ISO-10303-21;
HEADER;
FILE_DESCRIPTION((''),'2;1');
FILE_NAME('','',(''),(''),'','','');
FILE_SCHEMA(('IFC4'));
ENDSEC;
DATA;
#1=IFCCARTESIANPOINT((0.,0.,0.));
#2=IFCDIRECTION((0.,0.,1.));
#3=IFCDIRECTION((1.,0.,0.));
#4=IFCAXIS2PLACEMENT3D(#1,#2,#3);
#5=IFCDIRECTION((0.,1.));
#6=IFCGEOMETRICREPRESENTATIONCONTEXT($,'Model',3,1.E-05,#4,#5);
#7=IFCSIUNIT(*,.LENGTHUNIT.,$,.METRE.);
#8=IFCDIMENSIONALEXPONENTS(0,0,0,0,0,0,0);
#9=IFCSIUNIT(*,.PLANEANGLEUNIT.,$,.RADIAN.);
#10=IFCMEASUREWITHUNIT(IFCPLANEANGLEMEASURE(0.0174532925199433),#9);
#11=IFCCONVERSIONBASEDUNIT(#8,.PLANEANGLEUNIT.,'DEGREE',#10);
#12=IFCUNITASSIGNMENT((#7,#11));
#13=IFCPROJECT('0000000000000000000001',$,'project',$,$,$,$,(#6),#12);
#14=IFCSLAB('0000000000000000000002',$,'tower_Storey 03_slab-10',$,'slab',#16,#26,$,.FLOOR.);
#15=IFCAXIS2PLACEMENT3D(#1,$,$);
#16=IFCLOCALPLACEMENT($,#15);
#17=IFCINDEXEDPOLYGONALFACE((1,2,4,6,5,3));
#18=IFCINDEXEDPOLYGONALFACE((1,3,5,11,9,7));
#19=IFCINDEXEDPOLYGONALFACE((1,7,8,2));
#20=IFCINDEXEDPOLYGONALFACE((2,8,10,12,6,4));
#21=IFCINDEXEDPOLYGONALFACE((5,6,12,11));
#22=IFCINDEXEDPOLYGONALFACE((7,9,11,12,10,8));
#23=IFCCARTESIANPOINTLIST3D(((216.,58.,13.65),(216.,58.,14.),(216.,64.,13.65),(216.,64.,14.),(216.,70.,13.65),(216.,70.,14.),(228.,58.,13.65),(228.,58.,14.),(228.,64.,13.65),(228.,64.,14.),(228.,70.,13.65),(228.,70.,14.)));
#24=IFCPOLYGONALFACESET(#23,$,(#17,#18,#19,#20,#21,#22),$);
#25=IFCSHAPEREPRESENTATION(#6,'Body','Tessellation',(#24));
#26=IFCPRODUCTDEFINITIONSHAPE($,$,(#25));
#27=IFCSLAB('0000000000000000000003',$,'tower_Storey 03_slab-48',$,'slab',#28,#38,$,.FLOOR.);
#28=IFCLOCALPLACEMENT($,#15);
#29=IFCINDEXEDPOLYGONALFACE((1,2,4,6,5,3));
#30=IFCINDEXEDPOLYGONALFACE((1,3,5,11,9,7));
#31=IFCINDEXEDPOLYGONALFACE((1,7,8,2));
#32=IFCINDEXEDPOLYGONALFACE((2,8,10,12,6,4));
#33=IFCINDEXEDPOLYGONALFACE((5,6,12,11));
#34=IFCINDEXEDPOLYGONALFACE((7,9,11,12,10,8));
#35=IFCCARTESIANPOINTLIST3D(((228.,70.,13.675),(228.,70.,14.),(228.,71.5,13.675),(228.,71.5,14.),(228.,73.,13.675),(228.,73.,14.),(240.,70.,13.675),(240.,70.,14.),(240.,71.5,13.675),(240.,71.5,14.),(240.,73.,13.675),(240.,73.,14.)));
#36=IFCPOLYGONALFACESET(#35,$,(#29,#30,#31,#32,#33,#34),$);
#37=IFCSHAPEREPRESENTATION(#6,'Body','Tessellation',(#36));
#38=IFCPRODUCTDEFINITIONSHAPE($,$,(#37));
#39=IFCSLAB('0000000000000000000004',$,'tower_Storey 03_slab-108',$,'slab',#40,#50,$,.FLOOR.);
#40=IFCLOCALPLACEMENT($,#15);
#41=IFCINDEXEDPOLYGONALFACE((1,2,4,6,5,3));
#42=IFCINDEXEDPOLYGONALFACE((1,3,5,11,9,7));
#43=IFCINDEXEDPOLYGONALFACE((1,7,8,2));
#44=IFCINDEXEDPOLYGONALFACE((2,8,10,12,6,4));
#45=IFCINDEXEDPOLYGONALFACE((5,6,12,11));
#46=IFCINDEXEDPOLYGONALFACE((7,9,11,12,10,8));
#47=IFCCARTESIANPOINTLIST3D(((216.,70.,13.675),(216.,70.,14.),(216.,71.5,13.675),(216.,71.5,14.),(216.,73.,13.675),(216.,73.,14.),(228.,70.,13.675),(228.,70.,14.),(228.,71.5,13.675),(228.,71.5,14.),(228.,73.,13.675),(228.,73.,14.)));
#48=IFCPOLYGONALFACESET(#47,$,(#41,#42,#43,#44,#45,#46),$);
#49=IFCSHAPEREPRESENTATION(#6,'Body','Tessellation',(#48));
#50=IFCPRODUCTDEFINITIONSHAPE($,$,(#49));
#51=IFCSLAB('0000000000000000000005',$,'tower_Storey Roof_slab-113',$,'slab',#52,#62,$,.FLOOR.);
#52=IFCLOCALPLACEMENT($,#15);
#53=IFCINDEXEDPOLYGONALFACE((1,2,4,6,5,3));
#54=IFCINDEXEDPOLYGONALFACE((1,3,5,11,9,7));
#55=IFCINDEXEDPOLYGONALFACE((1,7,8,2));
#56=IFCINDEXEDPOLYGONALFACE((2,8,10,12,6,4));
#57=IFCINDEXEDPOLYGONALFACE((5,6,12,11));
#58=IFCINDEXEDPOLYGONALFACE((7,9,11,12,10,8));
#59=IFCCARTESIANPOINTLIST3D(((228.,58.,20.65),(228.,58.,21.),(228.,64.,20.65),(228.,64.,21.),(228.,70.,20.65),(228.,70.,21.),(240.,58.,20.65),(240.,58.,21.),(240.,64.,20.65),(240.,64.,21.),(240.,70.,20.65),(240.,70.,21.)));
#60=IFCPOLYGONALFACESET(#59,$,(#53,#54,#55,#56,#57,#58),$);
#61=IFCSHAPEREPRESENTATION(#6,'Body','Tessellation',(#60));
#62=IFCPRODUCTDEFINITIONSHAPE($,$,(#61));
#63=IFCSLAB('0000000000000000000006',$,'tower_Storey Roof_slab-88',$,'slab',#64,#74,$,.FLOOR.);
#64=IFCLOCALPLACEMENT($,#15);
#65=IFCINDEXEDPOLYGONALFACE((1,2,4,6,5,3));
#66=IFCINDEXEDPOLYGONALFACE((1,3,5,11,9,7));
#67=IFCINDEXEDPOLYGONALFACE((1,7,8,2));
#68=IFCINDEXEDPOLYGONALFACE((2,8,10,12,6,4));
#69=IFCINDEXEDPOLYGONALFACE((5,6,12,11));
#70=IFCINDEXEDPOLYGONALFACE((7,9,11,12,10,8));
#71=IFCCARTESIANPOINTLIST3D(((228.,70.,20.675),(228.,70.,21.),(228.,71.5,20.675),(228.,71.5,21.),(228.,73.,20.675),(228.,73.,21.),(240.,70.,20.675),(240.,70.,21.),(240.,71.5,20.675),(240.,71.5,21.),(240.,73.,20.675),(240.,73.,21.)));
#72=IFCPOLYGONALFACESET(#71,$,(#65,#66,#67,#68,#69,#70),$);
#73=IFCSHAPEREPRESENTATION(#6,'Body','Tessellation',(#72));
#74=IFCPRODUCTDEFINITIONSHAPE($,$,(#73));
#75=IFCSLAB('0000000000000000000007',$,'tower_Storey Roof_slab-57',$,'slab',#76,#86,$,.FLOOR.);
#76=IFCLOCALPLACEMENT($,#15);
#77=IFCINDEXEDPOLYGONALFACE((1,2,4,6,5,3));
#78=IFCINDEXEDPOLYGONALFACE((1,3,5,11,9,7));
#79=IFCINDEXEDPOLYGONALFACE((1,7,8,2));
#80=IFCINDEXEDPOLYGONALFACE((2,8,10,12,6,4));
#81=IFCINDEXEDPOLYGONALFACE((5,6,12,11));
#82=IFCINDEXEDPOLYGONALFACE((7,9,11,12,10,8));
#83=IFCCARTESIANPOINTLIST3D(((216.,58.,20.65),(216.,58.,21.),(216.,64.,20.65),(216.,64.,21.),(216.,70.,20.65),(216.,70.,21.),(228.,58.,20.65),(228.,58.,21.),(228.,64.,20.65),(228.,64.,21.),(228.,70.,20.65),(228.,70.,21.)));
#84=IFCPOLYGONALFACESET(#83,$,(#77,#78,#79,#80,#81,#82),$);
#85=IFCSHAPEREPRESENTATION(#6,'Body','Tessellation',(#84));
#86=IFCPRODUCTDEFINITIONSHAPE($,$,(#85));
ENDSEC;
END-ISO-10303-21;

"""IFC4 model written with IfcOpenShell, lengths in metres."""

from ifc_helpers import new_model, entity, si_unit, converted_unit, direction, frame, origin_with_axes, place, context, project, polyline, outline, extrude, element, save


model = new_model("IFC4")

# Units and contexts
model_context = context("Model", 3, precision=1e-05, world=origin_with_axes(), true_north=direction((0.0, 1.0)))
ifc_project = project(units=[si_unit("LENGTHUNIT", "METRE"), converted_unit("PLANEANGLEUNIT", "DEGREE", entity("IfcPlaneAngleMeasure", 0.0174532925199433), si_unit("PLANEANGLEUNIT", "RADIAN"), dimensions=[0, 0, 0, 0, 0, 0, 0])], contexts=[model_context])

# Shared definitions
placement_1 = place(None, origin_with_axes())
placement_2 = place(placement_1, frame((0.0, 0.0, 14.0), z_axis=(0.0, 0.0, 1.0), x_axis=(1.0, 0.0, 0.0)))

# Shared definitions
placement_3 = place(placement_1, frame((0.0, 0.0, 21.0), z_axis=(0.0, 0.0, 1.0), x_axis=(1.0, 0.0, 0.0)))

# Slabs
slab_1_placement = place(placement_2, frame((222.0, 64.0, -0.35), z_axis=(0.0, 0.0, 1.0), x_axis=(1.0, 0.0, 0.0)))
element("IfcSlab", 1, at=slab_1_placement, Name="tower_Storey 03_slab-10", ObjectType="slab", PredefinedType="FLOOR", context=model_context, body=[
    extrude(outline(polyline([(-6.0, 0.0, 0.0), (-6.0, -6.0, 0.0), (6.0, -6.0, 0.0), (6.0, 0.0, 0.0), (6.0, 6.0, 0.0), (-6.0, 6.0, 0.0), (-6.0, 0.0, 0.0)])), origin_with_axes(), (0.0, 0.0, 1.0), 0.35),
])
for number, where, z_axis, x_axis, name in (
    (2, (234.0, 71.5, -0.325), (0.0, 0.0, 1.0), (1.0, 0.0, 0.0), "tower_Storey 03_slab-48"),
    (3, (222.0, 71.5, -0.325), (0.0, 0.0, 1.0), (1.0, 0.0, 0.0), "tower_Storey 03_slab-108"),
):
    element("IfcSlab", number, at=place(placement_2, frame(where, z_axis=z_axis, x_axis=x_axis)), Name=name, ObjectType="slab", PredefinedType="FLOOR", context=model_context, body=[
        extrude(outline(polyline([(-6.0, 0.0, 0.0), (-6.0, -1.5, 0.0), (6.0, -1.5, 0.0), (6.0, 0.0, 0.0), (6.0, 1.5, 0.0), (-6.0, 1.5, 0.0), (-6.0, 0.0, 0.0)])), origin_with_axes(), (0.0, 0.0, 1.0), 0.325),
    ])
slab_2_placement = place(placement_3, frame((234.0, 64.0, -0.35), z_axis=(0.0, 0.0, 1.0), x_axis=(1.0, 0.0, 0.0)))
element("IfcSlab", 4, at=slab_2_placement, Name="tower_Storey Roof_slab-113", ObjectType="slab", PredefinedType="FLOOR", context=model_context, body=[
    extrude(outline(polyline([(-6.0, -6.0, 0.0), (6.0, -6.0, 0.0), (6.0, 0.0, 0.0), (6.0, 6.0, 0.0), (-6.0, 6.0, 0.0), (-6.0, 0.0, 0.0), (-6.0, -6.0, 0.0)])), origin_with_axes(), (0.0, 0.0, 1.0), 0.35),
])
slab_3_placement = place(placement_3, frame((234.0, 71.5, -0.325), z_axis=(0.0, 0.0, 1.0), x_axis=(1.0, 0.0, 0.0)))
element("IfcSlab", 5, at=slab_3_placement, Name="tower_Storey Roof_slab-88", ObjectType="slab", PredefinedType="FLOOR", context=model_context, body=[
    extrude(outline(polyline([(-6.0, 0.0, 0.0), (-6.0, -1.5, 0.0), (6.0, -1.5, 0.0), (6.0, 0.0, 0.0), (6.0, 1.5, 0.0), (-6.0, 1.5, 0.0), (-6.0, 0.0, 0.0)])), origin_with_axes(), (0.0, 0.0, 1.0), 0.325),
])
slab_4_placement = place(placement_3, frame((222.0, 64.0, -0.35), z_axis=(0.0, 0.0, 1.0), x_axis=(1.0, 0.0, 0.0)))
element("IfcSlab", 6, at=slab_4_placement, Name="tower_Storey Roof_slab-57", ObjectType="slab", PredefinedType="FLOOR", context=model_context, body=[
    extrude(outline(polyline([(-6.0, 0.0, 0.0), (-6.0, -6.0, 0.0), (6.0, -6.0, 0.0), (6.0, 0.0, 0.0), (6.0, 6.0, 0.0), (-6.0, 6.0, 0.0), (-6.0, 0.0, 0.0)])), origin_with_axes(), (0.0, 0.0, 1.0), 0.35),
])

save(model, "model.ifc")
